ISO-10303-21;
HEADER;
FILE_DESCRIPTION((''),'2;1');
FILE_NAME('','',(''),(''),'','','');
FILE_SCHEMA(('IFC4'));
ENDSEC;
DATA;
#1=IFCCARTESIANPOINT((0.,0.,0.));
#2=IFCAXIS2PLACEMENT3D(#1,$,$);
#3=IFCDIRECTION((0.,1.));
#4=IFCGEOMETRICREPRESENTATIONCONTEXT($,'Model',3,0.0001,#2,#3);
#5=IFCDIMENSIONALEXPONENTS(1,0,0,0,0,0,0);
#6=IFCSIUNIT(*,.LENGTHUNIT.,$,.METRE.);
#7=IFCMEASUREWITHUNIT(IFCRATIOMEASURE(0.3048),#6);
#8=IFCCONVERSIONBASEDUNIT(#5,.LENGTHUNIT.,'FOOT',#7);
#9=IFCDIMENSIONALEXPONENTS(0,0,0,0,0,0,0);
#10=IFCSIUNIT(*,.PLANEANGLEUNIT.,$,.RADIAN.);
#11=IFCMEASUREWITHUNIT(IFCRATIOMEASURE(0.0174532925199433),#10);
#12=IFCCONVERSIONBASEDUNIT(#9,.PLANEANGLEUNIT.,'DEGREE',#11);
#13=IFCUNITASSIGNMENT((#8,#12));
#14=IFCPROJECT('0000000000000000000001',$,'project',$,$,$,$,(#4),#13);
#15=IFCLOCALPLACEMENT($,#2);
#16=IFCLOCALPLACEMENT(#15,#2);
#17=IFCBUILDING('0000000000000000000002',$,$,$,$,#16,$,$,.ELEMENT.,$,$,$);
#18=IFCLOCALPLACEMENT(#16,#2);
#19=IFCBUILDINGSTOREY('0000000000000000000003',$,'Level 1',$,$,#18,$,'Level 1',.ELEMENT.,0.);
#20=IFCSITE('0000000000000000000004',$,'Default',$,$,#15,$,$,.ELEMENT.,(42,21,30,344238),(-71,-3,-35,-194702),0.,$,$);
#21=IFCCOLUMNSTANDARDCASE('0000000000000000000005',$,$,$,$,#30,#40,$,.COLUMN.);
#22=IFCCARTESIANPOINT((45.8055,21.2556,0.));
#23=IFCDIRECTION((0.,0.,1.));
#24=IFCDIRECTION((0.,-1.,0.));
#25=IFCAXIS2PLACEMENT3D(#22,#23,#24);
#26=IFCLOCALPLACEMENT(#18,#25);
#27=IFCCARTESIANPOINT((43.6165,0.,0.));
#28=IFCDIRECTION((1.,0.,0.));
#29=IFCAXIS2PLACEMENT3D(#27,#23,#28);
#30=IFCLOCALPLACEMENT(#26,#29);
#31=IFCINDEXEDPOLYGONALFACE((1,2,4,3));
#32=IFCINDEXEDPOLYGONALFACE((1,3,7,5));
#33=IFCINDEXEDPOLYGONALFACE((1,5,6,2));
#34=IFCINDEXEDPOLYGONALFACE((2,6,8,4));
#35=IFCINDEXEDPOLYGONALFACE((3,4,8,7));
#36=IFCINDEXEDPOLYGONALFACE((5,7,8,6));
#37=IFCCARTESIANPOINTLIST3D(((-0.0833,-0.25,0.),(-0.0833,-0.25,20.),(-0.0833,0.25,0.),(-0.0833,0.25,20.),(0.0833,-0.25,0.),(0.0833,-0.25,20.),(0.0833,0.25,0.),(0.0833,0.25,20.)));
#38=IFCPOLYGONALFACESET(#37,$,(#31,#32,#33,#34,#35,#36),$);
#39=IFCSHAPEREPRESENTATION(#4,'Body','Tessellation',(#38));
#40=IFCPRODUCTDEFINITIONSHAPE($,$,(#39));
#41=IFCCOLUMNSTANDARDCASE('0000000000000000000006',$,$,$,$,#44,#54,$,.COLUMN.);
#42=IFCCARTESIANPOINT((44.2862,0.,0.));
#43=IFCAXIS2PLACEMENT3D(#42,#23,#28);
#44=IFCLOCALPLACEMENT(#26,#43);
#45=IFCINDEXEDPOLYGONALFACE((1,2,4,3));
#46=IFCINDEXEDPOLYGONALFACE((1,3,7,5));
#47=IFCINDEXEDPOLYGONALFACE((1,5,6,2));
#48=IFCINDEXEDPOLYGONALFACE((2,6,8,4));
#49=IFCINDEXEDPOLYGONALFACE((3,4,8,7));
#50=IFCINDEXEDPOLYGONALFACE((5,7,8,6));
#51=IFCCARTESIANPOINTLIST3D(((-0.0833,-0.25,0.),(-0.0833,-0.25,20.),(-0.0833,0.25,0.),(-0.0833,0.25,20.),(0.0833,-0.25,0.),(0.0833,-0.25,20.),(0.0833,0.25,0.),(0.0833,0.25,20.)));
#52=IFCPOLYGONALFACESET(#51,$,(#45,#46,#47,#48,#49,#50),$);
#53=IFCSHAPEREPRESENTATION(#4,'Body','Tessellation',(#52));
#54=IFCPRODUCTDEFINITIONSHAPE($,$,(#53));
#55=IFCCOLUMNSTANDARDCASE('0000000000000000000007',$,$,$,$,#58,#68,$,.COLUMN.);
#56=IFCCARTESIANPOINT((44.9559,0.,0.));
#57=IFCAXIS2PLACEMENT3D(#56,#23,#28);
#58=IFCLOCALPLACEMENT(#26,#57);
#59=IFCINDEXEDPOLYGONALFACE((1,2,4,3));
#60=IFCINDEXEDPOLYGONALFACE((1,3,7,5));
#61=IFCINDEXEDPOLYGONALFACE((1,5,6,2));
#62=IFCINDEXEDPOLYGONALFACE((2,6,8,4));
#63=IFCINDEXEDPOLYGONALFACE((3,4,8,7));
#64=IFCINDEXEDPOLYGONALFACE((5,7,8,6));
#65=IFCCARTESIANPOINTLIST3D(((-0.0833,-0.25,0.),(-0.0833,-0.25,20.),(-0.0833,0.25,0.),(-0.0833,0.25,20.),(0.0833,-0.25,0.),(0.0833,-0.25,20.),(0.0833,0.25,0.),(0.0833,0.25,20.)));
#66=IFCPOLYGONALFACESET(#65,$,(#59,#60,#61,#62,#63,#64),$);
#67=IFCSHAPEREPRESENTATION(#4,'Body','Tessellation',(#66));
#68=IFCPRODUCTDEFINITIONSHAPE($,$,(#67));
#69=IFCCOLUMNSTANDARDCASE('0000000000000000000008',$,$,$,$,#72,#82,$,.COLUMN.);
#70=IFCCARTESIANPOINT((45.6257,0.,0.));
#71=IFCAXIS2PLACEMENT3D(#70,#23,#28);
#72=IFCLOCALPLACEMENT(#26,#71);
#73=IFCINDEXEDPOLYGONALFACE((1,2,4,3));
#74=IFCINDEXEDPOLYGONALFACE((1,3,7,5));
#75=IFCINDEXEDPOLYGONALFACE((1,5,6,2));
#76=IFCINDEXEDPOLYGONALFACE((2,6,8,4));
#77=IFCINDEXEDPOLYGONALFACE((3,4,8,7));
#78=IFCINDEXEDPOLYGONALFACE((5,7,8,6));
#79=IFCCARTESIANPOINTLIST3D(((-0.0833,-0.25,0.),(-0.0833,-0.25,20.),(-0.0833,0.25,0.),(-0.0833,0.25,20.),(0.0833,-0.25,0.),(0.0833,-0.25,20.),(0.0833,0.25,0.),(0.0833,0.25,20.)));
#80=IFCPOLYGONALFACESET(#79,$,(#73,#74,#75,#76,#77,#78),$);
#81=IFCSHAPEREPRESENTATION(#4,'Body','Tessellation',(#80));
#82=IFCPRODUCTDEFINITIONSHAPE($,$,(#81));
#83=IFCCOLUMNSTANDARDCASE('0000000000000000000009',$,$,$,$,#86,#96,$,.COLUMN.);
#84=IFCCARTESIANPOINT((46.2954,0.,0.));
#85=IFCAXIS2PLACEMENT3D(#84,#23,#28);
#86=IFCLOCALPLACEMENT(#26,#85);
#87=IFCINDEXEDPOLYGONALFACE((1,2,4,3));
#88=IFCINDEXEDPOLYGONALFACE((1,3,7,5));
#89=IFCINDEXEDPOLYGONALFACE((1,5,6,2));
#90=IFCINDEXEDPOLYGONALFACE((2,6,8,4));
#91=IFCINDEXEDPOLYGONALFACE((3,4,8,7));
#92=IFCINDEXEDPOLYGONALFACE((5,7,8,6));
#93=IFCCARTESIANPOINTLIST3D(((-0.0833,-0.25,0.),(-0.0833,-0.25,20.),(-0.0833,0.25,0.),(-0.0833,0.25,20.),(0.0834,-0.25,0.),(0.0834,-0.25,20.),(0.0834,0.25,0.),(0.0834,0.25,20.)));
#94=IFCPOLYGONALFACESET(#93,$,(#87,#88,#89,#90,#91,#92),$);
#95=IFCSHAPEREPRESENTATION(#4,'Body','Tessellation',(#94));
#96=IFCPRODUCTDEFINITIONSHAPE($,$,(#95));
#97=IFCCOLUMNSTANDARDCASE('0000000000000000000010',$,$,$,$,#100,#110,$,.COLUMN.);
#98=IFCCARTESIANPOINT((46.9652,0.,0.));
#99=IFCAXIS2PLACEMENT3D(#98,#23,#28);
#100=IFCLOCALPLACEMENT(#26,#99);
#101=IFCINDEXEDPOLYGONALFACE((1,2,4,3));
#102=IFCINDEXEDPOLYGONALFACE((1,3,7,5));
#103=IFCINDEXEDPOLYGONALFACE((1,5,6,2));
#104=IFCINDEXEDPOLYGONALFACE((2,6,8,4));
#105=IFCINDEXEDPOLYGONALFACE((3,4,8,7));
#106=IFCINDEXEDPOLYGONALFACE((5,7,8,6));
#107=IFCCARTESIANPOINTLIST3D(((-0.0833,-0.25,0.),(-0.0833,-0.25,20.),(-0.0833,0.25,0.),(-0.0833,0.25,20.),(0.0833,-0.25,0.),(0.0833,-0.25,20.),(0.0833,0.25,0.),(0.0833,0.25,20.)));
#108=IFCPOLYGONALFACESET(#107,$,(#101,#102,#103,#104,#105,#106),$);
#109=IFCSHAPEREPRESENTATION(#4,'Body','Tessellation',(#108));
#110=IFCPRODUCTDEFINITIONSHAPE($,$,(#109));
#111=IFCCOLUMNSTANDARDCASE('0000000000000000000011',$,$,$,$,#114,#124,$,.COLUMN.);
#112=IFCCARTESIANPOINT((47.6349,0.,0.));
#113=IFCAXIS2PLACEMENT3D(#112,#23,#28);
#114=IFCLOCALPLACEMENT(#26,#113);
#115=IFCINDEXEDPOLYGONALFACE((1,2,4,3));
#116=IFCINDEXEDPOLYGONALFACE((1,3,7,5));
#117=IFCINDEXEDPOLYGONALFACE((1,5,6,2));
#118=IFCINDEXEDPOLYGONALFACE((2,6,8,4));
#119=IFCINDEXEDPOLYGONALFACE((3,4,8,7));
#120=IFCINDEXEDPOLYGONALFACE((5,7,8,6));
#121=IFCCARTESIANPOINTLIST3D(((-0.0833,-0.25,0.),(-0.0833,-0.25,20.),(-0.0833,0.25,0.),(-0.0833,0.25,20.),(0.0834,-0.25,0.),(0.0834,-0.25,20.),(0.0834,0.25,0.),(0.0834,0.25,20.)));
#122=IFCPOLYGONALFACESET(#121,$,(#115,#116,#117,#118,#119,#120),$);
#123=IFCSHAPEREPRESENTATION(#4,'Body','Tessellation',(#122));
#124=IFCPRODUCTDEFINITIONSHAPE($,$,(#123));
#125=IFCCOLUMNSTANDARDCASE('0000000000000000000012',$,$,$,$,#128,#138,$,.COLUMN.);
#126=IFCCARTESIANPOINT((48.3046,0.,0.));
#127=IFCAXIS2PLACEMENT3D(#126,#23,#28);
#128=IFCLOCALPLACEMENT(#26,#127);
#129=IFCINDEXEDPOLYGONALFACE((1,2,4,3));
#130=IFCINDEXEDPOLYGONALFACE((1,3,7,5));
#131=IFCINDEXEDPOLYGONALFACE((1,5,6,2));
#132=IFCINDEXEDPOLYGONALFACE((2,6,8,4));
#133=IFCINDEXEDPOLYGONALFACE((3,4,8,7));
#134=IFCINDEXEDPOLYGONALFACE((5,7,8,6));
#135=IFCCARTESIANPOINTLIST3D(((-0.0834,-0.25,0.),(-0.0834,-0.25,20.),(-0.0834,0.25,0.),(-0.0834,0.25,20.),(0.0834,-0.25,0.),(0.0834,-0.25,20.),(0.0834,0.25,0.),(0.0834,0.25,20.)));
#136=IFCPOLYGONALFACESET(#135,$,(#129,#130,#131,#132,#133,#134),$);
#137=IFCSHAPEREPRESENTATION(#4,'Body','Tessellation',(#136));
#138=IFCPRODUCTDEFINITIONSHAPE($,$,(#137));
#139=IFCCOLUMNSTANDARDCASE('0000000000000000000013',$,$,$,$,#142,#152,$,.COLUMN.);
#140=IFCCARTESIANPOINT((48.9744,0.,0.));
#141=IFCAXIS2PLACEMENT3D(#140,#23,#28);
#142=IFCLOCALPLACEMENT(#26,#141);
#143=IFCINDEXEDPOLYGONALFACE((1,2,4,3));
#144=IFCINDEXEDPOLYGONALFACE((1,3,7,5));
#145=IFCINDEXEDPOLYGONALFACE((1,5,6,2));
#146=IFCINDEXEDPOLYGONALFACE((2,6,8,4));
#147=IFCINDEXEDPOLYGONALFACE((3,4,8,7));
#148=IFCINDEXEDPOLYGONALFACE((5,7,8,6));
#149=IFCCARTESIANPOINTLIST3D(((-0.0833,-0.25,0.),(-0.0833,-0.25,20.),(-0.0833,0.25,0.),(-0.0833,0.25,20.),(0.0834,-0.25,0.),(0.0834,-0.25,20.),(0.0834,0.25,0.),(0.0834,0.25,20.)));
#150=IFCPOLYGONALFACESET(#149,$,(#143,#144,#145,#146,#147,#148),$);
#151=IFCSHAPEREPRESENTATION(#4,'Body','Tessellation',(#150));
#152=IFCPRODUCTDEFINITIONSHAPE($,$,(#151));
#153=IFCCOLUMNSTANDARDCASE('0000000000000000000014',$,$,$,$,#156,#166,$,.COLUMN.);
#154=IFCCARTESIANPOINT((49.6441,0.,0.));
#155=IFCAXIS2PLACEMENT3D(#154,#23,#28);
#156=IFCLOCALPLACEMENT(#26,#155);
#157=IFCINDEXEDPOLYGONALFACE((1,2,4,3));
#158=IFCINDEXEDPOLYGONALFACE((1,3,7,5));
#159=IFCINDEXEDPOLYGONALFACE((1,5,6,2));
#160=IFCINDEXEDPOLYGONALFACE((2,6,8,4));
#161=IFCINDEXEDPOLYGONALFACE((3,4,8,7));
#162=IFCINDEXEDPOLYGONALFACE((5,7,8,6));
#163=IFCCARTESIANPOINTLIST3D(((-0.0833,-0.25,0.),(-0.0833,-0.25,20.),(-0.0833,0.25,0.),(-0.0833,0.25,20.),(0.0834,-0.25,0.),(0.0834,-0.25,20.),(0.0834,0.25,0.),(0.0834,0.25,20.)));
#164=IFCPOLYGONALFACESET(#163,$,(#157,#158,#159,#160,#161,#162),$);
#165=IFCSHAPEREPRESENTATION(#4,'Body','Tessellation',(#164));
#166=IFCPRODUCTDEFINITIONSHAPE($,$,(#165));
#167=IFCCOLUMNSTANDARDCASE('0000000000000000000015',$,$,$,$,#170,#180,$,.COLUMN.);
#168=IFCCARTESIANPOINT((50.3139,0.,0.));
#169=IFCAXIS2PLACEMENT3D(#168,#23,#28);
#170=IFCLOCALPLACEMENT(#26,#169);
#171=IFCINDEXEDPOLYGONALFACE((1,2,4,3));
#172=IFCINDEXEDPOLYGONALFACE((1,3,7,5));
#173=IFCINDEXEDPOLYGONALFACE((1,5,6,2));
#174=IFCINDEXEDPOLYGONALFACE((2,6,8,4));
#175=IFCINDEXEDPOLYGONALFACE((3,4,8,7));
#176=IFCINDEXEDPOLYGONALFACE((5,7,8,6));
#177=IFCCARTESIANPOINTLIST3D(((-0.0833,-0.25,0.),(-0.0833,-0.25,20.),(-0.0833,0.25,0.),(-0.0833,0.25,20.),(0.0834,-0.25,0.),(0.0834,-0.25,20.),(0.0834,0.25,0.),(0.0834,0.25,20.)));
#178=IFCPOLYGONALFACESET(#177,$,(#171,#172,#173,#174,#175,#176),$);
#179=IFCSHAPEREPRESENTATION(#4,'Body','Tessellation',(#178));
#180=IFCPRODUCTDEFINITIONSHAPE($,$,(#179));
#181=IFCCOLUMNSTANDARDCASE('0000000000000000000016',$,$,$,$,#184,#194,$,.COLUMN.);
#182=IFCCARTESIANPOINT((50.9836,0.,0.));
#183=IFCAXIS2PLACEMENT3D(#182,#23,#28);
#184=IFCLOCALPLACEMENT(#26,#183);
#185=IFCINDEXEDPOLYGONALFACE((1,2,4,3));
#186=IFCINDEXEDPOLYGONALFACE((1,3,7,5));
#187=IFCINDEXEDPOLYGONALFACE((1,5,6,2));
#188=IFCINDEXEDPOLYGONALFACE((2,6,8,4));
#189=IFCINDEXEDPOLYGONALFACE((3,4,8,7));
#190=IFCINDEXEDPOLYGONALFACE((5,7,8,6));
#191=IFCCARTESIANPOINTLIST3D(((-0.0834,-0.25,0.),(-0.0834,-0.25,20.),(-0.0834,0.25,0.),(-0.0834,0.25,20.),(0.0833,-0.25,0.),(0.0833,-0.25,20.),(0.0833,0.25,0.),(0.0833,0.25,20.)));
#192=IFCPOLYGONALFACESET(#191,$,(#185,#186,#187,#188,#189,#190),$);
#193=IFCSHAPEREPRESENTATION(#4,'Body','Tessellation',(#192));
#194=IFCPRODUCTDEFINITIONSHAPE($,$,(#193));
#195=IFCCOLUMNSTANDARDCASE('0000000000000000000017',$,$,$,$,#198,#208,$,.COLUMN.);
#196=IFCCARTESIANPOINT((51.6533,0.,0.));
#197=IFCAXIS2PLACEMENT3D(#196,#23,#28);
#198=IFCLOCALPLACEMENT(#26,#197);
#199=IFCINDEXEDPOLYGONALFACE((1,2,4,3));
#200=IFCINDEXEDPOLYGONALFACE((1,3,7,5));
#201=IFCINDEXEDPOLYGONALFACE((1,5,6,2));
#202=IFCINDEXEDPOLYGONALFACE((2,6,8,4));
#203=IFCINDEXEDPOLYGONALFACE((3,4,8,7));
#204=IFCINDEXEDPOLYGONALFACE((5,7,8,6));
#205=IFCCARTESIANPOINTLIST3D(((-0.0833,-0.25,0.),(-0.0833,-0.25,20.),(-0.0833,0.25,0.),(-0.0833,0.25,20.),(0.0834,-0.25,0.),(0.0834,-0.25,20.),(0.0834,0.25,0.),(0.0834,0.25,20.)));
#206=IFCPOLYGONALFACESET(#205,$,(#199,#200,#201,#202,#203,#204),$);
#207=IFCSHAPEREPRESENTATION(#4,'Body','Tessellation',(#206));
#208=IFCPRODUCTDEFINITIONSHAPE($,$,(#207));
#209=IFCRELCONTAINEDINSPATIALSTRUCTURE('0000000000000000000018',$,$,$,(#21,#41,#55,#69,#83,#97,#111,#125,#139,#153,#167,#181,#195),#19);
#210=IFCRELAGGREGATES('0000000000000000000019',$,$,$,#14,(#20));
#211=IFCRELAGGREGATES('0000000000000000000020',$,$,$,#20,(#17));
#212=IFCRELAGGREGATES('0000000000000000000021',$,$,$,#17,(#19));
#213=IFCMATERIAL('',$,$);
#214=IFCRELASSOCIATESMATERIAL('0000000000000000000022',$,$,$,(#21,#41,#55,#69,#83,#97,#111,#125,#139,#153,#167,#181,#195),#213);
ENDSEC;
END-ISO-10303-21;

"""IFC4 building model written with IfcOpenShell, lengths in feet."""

from ifc_helpers import new_model, entity, si_unit, converted_unit, direction, frame, origin, place, context, project, spatial, rectangle, extrude, material, element, save


model = new_model("IFC4")

# Units and contexts
model_context = context("Model", 3, precision=0.0001, world=origin(), true_north=direction((0.0, 1.0)))
ifc_project = project(units=[converted_unit("LENGTHUNIT", "FOOT", entity("IfcRatioMeasure", 0.3048), si_unit("LENGTHUNIT", "METRE"), dimensions=[1, 0, 0, 0, 0, 0, 0]), converted_unit("PLANEANGLEUNIT", "DEGREE", entity("IfcRatioMeasure", 0.0174532925199433), si_unit("PLANEANGLEUNIT", "RADIAN"), dimensions=[0, 0, 0, 0, 0, 0, 0])], contexts=[model_context])

# Site, building, storey
site_placement = place(None, origin())
site = spatial("IfcSite", under=ifc_project, at=site_placement, Name="Default", CompositionType="ELEMENT", RefLatitude=(42, 21, 30, 344238), RefLongitude=(-71, -3, -35, -194702), RefElevation=0.0)
building_placement = place(site_placement, origin())
building = spatial("IfcBuilding", under=site, at=building_placement, CompositionType="ELEMENT")
storey_placement = place(building_placement, origin())
storey = spatial("IfcBuildingStorey", under=building, at=storey_placement, Name="Level 1", LongName="Level 1", CompositionType="ELEMENT", Elevation=0.0)

# Columns
ifc_material_1 = material(Name="")
placement = place(storey_placement, frame((45.8055, 21.2556, 0.0), z_axis=(0.0, 0.0, 1.0), x_axis=(0.0, -1.0, 0.0)))
for number, where, z_axis, x_axis in (
    (1, (43.6165, 0.0, 0.0), (0.0, 0.0, 1.0), (1.0, 0.0, 0.0)),
    (2, (44.2862, 0.0, 0.0), (0.0, 0.0, 1.0), (1.0, 0.0, 0.0)),
    (3, (44.9559, 0.0, 0.0), (0.0, 0.0, 1.0), (1.0, 0.0, 0.0)),
    (4, (45.6257, 0.0, 0.0), (0.0, 0.0, 1.0), (1.0, 0.0, 0.0)),
    (5, (46.2954, 0.0, 0.0), (0.0, 0.0, 1.0), (1.0, 0.0, 0.0)),
    (6, (46.9652, 0.0, 0.0), (0.0, 0.0, 1.0), (1.0, 0.0, 0.0)),
    (7, (47.6349, 0.0, 0.0), (0.0, 0.0, 1.0), (1.0, 0.0, 0.0)),
    (8, (48.3046, 0.0, 0.0), (0.0, 0.0, 1.0), (1.0, 0.0, 0.0)),
    (9, (48.9744, 0.0, 0.0), (0.0, 0.0, 1.0), (1.0, 0.0, 0.0)),
    (10, (49.6441, 0.0, 0.0), (0.0, 0.0, 1.0), (1.0, 0.0, 0.0)),
    (11, (50.3139, 0.0, 0.0), (0.0, 0.0, 1.0), (1.0, 0.0, 0.0)),
    (12, (50.9836, 0.0, 0.0), (0.0, 0.0, 1.0), (1.0, 0.0, 0.0)),
    (13, (51.6533, 0.0, 0.0), (0.0, 0.0, 1.0), (1.0, 0.0, 0.0)),
):
    element("IfcColumnStandardCase", number, at=place(placement, frame(where, z_axis=z_axis, x_axis=x_axis)), inside=storey, material=ifc_material_1, PredefinedType="COLUMN", context=model_context, shape_type="SweptSolid", body=[
        extrude(rectangle(XDim=0.1667, YDim=0.5), origin(), (0.0, 0.0, 1.0), 20.0),
    ])

save(model, "model.ifc")
